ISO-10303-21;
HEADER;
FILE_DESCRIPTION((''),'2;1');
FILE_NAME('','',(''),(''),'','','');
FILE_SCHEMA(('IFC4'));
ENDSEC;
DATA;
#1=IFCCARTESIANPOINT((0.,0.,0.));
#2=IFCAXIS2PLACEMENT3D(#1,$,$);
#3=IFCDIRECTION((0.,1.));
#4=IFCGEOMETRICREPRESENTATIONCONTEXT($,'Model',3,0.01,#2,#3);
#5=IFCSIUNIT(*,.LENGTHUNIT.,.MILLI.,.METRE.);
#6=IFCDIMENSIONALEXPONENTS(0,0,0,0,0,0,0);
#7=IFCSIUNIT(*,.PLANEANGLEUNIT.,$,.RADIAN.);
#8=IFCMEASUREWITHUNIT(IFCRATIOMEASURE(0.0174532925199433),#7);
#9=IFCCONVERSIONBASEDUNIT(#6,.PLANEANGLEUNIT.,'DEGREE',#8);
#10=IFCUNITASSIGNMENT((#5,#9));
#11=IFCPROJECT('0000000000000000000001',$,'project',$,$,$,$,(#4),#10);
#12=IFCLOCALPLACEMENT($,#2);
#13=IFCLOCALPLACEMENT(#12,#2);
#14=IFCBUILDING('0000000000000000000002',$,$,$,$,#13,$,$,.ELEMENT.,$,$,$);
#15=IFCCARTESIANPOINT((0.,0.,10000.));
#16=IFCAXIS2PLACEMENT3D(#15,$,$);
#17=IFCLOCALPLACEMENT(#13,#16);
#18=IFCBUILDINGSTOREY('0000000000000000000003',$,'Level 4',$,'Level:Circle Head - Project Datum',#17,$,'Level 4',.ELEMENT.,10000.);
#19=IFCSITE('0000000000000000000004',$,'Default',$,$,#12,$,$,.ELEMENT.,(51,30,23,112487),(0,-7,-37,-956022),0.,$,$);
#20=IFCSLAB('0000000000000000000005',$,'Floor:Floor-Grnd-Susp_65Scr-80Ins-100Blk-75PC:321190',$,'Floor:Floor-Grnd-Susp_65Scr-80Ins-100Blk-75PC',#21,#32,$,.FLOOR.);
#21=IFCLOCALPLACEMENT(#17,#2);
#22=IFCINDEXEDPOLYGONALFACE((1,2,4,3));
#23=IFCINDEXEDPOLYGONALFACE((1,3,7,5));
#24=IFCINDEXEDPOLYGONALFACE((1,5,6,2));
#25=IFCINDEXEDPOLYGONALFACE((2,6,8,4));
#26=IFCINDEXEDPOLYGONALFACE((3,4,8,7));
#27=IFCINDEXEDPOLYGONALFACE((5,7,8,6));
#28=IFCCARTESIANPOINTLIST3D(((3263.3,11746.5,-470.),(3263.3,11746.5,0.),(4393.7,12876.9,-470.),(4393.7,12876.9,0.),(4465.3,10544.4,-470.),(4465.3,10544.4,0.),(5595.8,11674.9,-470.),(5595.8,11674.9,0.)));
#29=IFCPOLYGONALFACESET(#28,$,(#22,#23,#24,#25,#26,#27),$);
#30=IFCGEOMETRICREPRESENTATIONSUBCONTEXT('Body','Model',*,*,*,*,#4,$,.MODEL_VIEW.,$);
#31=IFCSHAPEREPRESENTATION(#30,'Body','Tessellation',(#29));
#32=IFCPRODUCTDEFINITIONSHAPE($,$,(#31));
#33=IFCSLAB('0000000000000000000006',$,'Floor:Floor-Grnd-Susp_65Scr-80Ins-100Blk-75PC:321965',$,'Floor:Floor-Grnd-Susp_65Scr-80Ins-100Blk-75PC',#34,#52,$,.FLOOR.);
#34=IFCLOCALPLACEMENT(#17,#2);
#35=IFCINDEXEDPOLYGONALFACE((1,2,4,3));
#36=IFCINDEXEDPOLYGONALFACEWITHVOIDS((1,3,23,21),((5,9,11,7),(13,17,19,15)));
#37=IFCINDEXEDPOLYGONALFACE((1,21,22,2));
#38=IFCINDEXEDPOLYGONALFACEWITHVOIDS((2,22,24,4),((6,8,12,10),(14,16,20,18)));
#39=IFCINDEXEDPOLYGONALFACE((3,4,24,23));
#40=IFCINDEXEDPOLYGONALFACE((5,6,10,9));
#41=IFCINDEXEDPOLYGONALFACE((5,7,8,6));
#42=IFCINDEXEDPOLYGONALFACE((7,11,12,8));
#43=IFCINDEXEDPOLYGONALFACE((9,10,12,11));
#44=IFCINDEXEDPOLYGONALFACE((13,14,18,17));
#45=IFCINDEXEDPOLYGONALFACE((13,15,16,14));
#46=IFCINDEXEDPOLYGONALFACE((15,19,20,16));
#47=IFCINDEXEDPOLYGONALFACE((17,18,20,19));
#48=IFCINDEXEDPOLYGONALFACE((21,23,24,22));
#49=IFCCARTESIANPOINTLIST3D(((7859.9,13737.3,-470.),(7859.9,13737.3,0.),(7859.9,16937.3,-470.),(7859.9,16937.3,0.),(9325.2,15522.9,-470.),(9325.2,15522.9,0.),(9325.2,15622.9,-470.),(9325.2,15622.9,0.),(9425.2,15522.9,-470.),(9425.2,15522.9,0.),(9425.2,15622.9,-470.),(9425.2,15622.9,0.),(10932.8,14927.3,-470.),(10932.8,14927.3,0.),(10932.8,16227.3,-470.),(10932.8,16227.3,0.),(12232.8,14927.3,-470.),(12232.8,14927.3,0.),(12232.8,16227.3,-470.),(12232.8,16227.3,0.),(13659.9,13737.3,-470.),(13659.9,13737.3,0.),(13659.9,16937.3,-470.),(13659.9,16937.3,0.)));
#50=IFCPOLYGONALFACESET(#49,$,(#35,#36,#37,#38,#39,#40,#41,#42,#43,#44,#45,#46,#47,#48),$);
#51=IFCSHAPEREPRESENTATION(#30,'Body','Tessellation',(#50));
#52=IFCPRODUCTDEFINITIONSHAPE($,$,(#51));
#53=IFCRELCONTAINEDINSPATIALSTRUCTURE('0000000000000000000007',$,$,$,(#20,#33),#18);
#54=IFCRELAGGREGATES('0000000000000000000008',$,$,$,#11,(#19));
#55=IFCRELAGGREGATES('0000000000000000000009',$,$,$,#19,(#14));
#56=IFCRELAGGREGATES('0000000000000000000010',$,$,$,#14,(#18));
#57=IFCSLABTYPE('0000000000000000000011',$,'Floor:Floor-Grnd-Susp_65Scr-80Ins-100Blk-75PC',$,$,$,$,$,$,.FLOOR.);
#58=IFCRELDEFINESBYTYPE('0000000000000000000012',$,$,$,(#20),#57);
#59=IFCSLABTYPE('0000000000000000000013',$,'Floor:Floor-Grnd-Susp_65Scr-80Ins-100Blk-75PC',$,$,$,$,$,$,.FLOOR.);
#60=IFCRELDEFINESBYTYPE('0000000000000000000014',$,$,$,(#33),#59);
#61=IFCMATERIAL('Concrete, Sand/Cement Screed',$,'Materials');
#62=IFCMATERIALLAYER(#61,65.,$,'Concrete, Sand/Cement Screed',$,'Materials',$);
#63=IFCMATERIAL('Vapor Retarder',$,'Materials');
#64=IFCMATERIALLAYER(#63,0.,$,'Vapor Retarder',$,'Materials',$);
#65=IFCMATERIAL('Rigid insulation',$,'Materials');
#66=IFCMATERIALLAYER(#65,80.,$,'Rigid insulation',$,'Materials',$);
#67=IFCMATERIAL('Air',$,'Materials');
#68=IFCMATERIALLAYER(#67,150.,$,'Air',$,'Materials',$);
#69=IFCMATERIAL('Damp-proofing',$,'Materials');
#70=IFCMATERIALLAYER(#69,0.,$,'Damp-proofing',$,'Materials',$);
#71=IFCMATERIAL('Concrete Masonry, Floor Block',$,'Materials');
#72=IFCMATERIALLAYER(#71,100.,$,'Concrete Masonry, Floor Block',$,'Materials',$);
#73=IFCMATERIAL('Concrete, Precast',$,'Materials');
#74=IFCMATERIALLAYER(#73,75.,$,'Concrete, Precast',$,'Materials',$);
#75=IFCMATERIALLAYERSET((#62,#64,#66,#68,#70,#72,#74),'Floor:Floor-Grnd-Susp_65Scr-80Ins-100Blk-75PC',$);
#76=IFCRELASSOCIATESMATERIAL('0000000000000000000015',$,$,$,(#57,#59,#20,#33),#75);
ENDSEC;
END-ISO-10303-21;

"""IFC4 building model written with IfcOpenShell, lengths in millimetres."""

from ifc_helpers import new_model, entity, si_unit, converted_unit, direction, frame, frame_2d, origin, place, context, subcontext, project, spatial, rectangle, extrude, material, layer, layer_set, layer_usage, type_object, element, save


model = new_model("IFC4")

# Units and contexts
model_context = context("Model", 3, precision=0.01, world=origin(), true_north=direction((0.0, 1.0)))
body_context = subcontext(model_context, "Body", "Model", "MODEL_VIEW")
ifc_project = project(units=[si_unit("LENGTHUNIT", "METRE", prefix="MILLI"), converted_unit("PLANEANGLEUNIT", "DEGREE", entity("IfcRatioMeasure", 0.0174532925199433), si_unit("PLANEANGLEUNIT", "RADIAN"), dimensions=[0, 0, 0, 0, 0, 0, 0])], contexts=[model_context])

# Site, building, storey
site_placement = place(None, origin())
site = spatial("IfcSite", under=ifc_project, at=site_placement, Name="Default", CompositionType="ELEMENT", RefLatitude=(51, 30, 23, 112487), RefLongitude=(0, -7, -37, -956022), RefElevation=0.0)
building_placement = place(site_placement, origin())
building = spatial("IfcBuilding", under=site, at=building_placement, CompositionType="ELEMENT")
storey_placement = place(building_placement, frame((0.0, 0.0, 10000.0)))
storey = spatial("IfcBuildingStorey", under=building, at=storey_placement, Name="Level 4", ObjectType="Level:Circle Head - Project Datum", LongName="Level 4", CompositionType="ELEMENT", Elevation=10000.0)

# Slab
ifc_material_1 = material(Name="Concrete, Sand/Cement Screed", Category="Materials")
ifc_layer_1 = layer(ifc_material_1, 65.0, Name="Concrete, Sand/Cement Screed", Category="Materials")
ifc_material_2 = material(Name="Vapor Retarder", Category="Materials")
ifc_layer_2 = layer(ifc_material_2, 0.0, Name="Vapor Retarder", Category="Materials")
ifc_material_3 = material(Name="Rigid insulation", Category="Materials")
ifc_layer_3 = layer(ifc_material_3, 80.0, Name="Rigid insulation", Category="Materials")
ifc_material_4 = material(Name="Air", Category="Materials")
ifc_layer_4 = layer(ifc_material_4, 150.0, Name="Air", Category="Materials")
ifc_material_5 = material(Name="Damp-proofing", Category="Materials")
ifc_layer_5 = layer(ifc_material_5, 0.0, Name="Damp-proofing", Category="Materials")
ifc_material_6 = material(Name="Concrete Masonry, Floor Block", Category="Materials")
ifc_layer_6 = layer(ifc_material_6, 100.0, Name="Concrete Masonry, Floor Block", Category="Materials")
ifc_material_7 = material(Name="Concrete, Precast", Category="Materials")
ifc_layer_7 = layer(ifc_material_7, 75.0, Name="Concrete, Precast", Category="Materials")
ifc_layer_set = layer_set([ifc_layer_1, ifc_layer_2, ifc_layer_3, ifc_layer_4, ifc_layer_5, ifc_layer_6, ifc_layer_7], Name="Floor:Floor-Grnd-Susp_65Scr-80Ins-100Blk-75PC")
ifc_layer_usage_1 = layer_usage(ifc_layer_set, "AXIS3", "POSITIVE", 0.0)
slab_type_1 = type_object("IfcSlabType", Name="Floor:Floor-Grnd-Susp_65Scr-80Ins-100Blk-75PC", PredefinedType="FLOOR", material=ifc_layer_set)
slab_1_placement = place(storey_placement, origin())
element("IfcSlab", 1, at=slab_1_placement, inside=storey, type_object=slab_type_1, material=ifc_layer_usage_1, Name="Floor:Floor-Grnd-Susp_65Scr-80Ins-100Blk-75PC:321190", ObjectType="Floor:Floor-Grnd-Susp_65Scr-80Ins-100Blk-75PC", PredefinedType="FLOOR", context=body_context, shape_type="SweptSolid", body=[
    extrude(rectangle(XDim=1700.0, YDim=1598.7, at=frame_2d((0.0, 0.0), x_axis=(1.0, 0.0))), frame((4429.5, 11710.7, 0.0), z_axis=(0.0, 0.0, -1.0), x_axis=(0.707107, -0.707107, 0.0)), (0.0, 0.0, 1.0), 470.0),
])

# Slab, openings
ifc_layer_usage_2 = layer_usage(ifc_layer_set, "AXIS3", "POSITIVE", 0.0)
slab_type_2 = type_object("IfcSlabType", Name="Floor:Floor-Grnd-Susp_65Scr-80Ins-100Blk-75PC", PredefinedType="FLOOR", material=ifc_layer_set)
slab_2_placement = place(storey_placement, frame((7859.9, 13737.3, -470.0)))
slab_2 = element("IfcSlab", 2, at=slab_2_placement, inside=storey, type_object=slab_type_2, material=ifc_layer_usage_2, Name="Floor:Floor-Grnd-Susp_65Scr-80Ins-100Blk-75PC:321965", ObjectType="Floor:Floor-Grnd-Susp_65Scr-80Ins-100Blk-75PC", PredefinedType="FLOOR", context=body_context, shape_type="SweptSolid", body=[
    extrude(rectangle(XDim=3200.0, YDim=5800.0, at=frame_2d((0.0, 0.0), x_axis=(0.0, -1.0))), frame((2900.0, 1600.0, 470.0), z_axis=(0.0, 0.0, -1.0), x_axis=(-1.0, 0.0, 0.0)), (0.0, 0.0, 1.0), 470.0),
])
opening_1_placement = place(storey_placement, frame((7859.9, 13737.3, -470.0)))
element("IfcOpeningElement", 3, at=opening_1_placement, cuts=slab_2, ObjectType="Opening", context=body_context, shape_type="SweptSolid", body=[
    extrude(rectangle(XDim=1300.0, YDim=1300.0, at=frame_2d((-822.9, 240.0), x_axis=(0.0, -1.0))), frame((2900.0, 1600.0, 470.0), z_axis=(0.0, 0.0, -1.0), x_axis=(-1.0, 0.0, 0.0)), (0.0, 0.0, 1.0), 470.0),
])
opening_2_placement = place(storey_placement, frame((7859.9, 13737.3, -470.0)))
element("IfcOpeningElement", 4, at=opening_2_placement, cuts=slab_2, ObjectType="Opening", context=body_context, shape_type="SweptSolid", body=[
    extrude(rectangle(XDim=100.0, YDim=100.0, at=frame_2d((1384.8, 235.6), x_axis=(0.0, -1.0))), frame((2900.0, 1600.0, 470.0), z_axis=(0.0, 0.0, -1.0), x_axis=(-1.0, 0.0, 0.0)), (0.0, 0.0, 1.0), 470.0),
])

save(model, "model.ifc")
